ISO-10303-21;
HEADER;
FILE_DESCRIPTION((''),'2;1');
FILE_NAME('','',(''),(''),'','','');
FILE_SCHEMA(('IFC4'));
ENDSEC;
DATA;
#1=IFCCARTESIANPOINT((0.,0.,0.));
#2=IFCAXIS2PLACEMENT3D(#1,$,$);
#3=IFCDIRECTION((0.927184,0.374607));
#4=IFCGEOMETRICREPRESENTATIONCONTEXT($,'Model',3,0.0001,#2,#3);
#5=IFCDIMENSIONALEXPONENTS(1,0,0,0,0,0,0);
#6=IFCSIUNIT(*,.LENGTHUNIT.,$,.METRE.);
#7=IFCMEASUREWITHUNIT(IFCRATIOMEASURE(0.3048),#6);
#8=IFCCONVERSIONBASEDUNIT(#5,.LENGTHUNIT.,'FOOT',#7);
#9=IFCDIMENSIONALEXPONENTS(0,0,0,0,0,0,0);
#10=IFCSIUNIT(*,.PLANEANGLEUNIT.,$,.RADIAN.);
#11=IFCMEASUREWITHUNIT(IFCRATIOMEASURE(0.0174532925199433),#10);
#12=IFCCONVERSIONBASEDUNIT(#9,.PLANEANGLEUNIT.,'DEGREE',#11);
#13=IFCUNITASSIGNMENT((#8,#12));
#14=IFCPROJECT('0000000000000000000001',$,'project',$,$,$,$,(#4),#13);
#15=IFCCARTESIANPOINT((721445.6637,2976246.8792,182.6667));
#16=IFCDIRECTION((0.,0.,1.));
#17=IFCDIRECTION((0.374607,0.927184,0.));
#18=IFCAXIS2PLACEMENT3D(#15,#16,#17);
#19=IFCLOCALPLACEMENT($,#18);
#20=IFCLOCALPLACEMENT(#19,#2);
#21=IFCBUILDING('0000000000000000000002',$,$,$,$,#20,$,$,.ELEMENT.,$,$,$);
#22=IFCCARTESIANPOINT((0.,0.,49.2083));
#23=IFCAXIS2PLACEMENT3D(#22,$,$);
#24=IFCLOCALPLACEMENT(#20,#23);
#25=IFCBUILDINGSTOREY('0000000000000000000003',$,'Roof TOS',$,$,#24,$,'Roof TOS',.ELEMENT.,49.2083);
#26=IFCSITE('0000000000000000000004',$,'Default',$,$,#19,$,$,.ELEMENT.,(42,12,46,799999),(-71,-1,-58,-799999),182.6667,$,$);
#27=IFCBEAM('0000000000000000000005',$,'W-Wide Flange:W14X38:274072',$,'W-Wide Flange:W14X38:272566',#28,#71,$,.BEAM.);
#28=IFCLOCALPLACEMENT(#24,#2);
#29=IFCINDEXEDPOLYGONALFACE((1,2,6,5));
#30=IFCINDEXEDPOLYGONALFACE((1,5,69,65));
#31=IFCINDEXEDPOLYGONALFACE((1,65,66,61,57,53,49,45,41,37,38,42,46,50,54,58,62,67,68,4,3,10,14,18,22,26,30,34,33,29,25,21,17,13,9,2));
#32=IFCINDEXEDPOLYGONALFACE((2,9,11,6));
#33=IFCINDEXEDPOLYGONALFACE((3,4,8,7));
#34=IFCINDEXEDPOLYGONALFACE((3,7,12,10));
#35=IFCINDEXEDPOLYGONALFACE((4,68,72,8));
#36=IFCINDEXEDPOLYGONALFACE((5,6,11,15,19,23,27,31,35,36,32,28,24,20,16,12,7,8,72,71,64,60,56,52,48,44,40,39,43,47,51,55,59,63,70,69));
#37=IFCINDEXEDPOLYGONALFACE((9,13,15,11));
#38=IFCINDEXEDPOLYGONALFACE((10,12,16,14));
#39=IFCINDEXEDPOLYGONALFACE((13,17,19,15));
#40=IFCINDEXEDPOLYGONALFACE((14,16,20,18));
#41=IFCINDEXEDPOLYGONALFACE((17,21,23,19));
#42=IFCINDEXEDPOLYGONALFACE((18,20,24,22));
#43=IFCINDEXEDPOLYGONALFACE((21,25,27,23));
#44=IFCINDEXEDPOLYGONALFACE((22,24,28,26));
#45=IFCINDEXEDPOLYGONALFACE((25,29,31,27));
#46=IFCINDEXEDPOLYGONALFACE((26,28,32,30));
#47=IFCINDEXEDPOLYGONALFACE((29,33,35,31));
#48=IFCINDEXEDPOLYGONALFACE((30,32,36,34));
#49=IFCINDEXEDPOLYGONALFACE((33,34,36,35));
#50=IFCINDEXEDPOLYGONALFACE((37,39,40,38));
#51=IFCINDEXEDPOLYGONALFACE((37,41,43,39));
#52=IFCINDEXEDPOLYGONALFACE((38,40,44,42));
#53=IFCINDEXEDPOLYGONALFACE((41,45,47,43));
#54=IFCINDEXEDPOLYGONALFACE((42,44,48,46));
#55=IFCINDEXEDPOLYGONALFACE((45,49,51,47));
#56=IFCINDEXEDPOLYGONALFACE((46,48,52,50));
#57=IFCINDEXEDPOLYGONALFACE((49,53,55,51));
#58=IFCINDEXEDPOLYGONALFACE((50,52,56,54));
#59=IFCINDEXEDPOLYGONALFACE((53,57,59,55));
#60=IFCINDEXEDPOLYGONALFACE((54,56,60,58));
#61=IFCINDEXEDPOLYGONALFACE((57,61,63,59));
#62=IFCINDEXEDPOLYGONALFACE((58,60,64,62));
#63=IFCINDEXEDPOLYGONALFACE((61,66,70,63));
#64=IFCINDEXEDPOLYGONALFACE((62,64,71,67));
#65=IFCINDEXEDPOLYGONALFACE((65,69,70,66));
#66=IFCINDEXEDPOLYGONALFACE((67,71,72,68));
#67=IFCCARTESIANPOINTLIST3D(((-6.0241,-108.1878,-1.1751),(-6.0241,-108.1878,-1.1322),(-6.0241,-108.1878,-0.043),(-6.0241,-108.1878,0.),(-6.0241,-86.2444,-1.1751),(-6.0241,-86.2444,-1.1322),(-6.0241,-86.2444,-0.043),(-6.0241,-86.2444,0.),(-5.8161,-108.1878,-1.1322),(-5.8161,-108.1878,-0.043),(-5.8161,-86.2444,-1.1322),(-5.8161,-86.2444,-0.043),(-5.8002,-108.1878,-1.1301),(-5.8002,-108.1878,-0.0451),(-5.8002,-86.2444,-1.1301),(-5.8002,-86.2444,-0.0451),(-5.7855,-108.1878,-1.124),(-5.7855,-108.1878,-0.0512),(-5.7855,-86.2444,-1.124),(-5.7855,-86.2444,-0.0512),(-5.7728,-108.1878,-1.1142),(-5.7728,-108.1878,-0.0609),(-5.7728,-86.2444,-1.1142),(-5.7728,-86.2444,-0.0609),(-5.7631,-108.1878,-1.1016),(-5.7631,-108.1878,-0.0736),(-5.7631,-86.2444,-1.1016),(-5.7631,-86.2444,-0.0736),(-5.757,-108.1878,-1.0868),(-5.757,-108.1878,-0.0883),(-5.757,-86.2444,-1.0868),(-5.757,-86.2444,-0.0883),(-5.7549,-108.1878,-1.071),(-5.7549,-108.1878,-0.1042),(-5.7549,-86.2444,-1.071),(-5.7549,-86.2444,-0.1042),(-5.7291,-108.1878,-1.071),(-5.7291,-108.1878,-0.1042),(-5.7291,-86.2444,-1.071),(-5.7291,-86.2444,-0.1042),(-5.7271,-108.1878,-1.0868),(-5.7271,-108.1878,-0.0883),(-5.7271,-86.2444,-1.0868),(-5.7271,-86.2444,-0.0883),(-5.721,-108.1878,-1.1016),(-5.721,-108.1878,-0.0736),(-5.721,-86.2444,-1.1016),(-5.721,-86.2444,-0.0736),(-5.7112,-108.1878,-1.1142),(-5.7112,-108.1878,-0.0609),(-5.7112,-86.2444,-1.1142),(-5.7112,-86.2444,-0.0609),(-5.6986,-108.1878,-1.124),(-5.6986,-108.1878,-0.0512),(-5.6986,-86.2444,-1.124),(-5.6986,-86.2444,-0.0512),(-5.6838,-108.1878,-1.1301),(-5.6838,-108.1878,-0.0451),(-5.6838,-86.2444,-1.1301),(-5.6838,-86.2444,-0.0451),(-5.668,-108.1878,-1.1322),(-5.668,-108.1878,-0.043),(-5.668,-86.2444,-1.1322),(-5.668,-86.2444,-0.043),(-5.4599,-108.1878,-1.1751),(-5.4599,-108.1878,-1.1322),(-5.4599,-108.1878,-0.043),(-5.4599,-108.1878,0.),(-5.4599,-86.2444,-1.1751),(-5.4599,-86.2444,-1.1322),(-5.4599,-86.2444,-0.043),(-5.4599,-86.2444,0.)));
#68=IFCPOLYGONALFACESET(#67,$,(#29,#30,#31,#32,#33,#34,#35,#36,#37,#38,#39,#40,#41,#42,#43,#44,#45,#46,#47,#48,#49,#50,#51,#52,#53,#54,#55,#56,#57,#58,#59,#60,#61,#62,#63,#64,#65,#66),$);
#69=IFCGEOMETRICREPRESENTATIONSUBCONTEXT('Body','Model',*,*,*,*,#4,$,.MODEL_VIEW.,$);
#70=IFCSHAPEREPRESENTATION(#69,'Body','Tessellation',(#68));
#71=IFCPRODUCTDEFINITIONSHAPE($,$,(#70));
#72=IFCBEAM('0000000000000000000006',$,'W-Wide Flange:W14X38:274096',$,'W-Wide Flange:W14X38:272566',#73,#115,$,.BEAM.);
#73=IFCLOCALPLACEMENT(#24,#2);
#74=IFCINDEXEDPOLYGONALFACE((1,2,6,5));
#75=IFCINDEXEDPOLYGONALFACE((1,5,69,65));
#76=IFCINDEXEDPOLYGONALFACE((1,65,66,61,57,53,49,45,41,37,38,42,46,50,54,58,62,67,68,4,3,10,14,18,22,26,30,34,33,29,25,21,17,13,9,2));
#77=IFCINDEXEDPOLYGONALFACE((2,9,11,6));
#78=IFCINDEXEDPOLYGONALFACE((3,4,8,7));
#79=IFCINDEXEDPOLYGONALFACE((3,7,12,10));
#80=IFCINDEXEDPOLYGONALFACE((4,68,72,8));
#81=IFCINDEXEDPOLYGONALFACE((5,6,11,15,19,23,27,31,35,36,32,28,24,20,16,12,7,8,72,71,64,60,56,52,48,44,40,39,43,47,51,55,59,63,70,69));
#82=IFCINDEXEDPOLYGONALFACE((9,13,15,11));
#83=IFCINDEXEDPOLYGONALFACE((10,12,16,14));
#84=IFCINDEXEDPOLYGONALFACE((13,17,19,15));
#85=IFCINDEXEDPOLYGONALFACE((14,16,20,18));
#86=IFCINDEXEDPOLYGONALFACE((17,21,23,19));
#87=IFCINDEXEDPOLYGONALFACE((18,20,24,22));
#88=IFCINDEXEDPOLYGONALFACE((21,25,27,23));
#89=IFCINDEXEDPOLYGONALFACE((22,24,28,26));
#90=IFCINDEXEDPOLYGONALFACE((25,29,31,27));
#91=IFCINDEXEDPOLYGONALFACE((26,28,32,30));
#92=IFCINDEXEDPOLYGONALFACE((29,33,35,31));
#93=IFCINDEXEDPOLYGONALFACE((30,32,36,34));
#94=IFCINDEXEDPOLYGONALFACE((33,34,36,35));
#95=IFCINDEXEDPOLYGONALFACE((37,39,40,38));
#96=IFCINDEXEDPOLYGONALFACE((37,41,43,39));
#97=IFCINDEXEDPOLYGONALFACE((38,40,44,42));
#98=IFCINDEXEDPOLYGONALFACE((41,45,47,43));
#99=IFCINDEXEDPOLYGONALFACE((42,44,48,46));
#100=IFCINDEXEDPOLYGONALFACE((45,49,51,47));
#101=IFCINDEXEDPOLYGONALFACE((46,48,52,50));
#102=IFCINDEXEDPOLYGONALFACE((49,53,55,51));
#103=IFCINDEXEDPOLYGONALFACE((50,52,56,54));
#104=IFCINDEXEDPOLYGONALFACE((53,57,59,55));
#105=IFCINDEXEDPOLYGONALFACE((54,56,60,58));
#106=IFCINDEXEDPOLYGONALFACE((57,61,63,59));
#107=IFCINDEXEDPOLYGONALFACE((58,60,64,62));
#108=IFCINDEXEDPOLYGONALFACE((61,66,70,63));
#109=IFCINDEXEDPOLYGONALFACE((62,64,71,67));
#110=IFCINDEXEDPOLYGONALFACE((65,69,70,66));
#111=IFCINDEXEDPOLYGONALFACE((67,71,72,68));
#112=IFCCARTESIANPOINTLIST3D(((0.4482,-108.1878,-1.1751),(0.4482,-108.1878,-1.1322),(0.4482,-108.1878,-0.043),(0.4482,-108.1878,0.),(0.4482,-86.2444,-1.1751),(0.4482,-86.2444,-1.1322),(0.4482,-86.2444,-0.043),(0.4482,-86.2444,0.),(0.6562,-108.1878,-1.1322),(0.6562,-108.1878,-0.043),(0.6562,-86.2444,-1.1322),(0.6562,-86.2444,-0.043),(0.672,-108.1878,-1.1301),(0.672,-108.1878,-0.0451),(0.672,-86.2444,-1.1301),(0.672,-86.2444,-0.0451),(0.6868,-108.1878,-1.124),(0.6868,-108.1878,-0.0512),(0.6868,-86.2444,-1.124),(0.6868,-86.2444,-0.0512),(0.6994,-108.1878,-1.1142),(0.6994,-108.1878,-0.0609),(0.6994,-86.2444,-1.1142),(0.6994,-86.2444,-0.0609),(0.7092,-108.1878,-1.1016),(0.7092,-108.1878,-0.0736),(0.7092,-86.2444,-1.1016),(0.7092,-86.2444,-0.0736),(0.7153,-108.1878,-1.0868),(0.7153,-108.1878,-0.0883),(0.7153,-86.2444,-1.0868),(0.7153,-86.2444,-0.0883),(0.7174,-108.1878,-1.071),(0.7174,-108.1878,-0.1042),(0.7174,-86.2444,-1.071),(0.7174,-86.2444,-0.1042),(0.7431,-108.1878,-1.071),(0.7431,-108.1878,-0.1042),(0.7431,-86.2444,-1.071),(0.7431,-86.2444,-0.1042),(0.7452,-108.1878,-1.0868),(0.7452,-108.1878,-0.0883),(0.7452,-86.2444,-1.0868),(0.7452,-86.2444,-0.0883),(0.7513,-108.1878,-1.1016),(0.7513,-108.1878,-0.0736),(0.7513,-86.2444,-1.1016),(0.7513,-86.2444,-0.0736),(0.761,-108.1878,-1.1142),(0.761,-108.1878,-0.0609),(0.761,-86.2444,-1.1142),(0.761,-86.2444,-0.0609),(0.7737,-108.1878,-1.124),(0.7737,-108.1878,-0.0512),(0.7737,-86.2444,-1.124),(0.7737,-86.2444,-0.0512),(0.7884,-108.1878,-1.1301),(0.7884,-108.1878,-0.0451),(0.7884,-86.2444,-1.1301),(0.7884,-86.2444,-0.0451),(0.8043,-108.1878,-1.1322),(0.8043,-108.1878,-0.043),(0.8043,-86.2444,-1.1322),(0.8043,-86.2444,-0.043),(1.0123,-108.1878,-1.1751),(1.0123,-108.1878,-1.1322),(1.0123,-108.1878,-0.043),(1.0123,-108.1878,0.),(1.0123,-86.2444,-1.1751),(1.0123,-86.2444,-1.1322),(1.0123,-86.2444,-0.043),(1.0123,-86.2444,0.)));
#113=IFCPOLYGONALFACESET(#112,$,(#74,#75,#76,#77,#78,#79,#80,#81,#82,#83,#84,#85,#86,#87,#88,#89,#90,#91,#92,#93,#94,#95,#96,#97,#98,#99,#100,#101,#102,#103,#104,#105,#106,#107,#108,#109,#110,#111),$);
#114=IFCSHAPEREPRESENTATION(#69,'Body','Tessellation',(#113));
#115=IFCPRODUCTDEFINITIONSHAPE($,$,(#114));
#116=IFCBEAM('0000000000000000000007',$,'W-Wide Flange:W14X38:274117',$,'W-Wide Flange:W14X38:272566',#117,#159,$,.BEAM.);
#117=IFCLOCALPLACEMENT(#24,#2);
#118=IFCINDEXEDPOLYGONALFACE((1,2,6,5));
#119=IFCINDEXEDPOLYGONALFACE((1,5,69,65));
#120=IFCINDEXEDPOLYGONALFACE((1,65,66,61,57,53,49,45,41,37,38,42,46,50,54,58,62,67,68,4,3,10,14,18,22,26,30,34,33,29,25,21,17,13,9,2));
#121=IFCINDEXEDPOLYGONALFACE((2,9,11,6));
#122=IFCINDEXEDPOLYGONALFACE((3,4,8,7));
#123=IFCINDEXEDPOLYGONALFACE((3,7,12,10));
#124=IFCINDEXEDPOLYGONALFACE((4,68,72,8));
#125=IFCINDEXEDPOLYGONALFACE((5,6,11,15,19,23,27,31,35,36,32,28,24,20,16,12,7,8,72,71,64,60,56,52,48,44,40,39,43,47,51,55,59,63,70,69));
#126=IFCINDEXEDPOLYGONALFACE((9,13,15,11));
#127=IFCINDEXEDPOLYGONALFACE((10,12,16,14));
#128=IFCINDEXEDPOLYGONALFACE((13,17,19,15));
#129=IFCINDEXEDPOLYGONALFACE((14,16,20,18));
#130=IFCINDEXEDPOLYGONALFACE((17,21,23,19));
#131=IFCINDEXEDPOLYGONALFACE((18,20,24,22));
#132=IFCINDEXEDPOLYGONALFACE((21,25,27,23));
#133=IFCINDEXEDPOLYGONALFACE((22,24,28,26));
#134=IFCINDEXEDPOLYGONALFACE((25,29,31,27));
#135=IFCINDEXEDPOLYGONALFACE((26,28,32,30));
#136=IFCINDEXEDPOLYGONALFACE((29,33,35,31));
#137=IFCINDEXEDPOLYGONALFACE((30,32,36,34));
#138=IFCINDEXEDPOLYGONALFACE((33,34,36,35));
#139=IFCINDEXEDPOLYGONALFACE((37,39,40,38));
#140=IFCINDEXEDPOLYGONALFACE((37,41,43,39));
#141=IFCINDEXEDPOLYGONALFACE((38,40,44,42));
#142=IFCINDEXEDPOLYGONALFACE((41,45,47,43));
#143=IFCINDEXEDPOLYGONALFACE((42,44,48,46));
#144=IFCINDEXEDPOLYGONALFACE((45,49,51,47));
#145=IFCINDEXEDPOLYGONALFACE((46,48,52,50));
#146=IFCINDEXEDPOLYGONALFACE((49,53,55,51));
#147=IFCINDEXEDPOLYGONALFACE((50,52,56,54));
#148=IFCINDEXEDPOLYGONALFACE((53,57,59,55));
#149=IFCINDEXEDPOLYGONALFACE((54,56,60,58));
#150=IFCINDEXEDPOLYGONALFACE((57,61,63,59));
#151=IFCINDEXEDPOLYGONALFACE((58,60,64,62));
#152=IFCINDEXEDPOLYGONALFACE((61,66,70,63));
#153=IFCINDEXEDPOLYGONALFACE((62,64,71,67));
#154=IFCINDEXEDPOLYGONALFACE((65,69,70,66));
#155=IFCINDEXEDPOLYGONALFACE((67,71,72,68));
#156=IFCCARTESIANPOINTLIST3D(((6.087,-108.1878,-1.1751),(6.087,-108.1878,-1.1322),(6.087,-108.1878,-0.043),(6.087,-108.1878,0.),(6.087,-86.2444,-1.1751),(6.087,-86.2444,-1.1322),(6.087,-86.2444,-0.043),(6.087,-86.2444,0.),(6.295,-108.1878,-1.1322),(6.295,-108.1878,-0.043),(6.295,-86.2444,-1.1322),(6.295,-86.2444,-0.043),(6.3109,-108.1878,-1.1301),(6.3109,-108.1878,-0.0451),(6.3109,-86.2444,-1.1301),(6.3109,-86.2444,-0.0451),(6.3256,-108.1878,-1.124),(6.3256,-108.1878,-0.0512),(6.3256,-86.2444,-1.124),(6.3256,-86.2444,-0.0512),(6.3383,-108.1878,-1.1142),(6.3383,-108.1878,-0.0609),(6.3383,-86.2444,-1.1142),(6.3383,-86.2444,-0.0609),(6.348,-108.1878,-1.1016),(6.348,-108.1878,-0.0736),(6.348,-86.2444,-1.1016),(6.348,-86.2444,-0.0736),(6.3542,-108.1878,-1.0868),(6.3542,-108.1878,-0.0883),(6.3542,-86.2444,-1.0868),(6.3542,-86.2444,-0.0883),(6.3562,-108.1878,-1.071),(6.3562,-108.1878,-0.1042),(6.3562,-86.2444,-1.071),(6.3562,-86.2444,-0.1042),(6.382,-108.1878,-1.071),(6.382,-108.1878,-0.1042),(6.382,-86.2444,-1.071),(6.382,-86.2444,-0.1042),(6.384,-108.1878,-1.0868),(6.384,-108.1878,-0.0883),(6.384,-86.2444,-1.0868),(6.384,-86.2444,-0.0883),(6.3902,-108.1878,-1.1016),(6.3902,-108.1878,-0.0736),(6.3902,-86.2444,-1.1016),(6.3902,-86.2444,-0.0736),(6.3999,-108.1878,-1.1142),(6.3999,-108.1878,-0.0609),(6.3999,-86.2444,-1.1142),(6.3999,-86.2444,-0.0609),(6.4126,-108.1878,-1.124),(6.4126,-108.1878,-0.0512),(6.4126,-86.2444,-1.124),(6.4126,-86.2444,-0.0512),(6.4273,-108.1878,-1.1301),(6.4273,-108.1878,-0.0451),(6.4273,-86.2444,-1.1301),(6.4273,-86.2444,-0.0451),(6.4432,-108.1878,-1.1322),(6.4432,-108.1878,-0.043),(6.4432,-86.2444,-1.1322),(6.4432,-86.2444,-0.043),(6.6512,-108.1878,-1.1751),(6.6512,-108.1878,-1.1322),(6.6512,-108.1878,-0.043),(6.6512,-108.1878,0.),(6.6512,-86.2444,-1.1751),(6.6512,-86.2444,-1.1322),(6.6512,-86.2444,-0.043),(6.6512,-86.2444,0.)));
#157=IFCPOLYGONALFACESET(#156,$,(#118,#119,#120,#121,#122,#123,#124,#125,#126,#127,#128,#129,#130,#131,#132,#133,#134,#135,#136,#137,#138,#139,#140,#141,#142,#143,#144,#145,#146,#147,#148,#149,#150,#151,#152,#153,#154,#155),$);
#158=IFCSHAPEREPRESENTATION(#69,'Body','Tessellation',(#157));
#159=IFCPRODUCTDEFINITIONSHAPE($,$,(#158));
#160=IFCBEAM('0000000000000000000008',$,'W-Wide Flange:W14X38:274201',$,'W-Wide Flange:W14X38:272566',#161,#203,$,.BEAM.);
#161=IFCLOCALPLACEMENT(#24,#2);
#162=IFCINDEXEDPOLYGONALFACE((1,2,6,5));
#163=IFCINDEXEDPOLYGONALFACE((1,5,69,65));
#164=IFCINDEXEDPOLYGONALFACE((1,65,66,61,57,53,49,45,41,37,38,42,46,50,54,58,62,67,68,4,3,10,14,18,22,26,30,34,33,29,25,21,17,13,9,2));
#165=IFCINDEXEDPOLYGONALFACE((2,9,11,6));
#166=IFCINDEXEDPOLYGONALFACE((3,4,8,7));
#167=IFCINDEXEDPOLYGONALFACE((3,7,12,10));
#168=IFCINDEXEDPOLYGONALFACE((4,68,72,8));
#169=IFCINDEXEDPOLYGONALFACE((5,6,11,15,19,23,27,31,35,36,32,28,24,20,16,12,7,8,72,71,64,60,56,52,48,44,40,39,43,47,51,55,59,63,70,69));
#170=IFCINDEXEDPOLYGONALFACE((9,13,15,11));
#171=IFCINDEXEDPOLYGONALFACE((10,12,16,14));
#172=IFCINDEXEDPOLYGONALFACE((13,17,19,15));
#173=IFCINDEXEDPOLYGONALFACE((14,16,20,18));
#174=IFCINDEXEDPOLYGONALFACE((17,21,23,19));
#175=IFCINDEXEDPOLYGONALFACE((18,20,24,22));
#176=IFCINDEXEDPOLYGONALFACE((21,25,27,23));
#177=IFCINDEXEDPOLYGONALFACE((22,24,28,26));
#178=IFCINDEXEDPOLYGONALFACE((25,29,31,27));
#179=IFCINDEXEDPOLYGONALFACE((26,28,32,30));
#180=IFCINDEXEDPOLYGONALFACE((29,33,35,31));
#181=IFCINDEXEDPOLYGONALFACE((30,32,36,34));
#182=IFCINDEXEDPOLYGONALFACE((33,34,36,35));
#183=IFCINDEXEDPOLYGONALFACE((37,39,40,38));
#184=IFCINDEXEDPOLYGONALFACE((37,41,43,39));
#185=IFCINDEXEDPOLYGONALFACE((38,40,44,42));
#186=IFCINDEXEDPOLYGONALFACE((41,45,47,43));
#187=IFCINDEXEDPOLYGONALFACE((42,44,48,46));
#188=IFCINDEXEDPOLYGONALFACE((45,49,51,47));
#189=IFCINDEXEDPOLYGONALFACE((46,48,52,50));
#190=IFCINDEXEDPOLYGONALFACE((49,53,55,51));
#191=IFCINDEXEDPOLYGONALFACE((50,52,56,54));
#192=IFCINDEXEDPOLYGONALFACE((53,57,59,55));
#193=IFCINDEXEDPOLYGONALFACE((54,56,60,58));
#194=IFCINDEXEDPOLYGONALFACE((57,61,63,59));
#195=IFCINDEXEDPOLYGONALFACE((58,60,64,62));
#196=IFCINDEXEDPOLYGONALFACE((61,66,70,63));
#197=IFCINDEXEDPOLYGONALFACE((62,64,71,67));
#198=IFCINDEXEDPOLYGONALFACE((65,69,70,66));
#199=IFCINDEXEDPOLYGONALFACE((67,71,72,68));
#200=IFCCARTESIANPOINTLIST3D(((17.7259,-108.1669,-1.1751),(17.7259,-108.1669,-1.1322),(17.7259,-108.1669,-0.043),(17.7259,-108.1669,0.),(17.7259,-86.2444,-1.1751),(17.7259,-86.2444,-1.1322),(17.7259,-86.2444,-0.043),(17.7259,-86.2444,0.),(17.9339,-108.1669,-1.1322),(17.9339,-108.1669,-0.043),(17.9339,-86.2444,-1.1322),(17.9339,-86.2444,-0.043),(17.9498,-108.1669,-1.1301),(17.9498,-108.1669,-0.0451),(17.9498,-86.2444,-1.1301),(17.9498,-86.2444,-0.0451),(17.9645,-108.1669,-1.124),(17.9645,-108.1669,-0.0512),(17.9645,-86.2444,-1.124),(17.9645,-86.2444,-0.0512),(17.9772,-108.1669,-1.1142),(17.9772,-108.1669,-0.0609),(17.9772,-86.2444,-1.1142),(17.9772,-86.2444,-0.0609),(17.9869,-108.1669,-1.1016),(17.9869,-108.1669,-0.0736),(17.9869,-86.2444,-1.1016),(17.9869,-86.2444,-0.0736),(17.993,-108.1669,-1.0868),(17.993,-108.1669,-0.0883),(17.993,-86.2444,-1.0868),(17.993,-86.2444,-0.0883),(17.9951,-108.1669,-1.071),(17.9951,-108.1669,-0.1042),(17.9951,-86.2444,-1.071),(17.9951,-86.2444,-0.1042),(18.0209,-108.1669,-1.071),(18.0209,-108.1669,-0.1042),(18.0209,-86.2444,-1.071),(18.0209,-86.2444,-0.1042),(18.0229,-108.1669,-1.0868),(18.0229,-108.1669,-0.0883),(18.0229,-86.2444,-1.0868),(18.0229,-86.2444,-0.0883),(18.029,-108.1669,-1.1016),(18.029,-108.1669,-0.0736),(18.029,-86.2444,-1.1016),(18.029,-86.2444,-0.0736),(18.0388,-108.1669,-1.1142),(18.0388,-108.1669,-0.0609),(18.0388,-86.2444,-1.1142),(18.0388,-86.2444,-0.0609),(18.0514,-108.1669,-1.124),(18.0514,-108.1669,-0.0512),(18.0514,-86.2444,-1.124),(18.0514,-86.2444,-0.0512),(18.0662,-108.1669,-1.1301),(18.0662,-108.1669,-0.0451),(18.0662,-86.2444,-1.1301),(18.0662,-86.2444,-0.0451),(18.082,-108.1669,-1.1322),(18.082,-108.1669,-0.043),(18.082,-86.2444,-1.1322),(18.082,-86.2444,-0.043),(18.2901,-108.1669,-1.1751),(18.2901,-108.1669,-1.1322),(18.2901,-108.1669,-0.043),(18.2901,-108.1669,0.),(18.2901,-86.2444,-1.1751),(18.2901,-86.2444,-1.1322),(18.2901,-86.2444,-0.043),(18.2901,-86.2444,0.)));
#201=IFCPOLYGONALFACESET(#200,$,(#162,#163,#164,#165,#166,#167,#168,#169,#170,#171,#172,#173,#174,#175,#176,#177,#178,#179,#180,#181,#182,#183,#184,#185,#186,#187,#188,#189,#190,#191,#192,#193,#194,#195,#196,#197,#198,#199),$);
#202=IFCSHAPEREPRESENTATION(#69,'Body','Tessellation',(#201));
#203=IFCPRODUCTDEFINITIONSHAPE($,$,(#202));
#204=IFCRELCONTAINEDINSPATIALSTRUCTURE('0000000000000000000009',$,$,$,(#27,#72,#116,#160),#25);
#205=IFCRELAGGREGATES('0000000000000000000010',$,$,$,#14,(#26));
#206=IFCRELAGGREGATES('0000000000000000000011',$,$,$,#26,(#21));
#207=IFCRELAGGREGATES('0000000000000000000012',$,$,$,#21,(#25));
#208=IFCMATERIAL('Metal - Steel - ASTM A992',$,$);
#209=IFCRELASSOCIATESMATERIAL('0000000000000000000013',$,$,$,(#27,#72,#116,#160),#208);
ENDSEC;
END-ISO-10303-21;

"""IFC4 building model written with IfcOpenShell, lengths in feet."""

from ifc_helpers import new_model, entity, si_unit, converted_unit, direction, frame, frame_2d, origin, place, context, subcontext, project, spatial, i_section, extrude, material, element, save


model = new_model("IFC4")

# Units and contexts
model_context = context("Model", 3, precision=0.0001, world=origin(), true_north=direction((0.927184, 0.374607)))
body_context = subcontext(model_context, "Body", "Model", "MODEL_VIEW")
ifc_project = project(units=[converted_unit("LENGTHUNIT", "FOOT", entity("IfcRatioMeasure", 0.3048), si_unit("LENGTHUNIT", "METRE"), dimensions=[1, 0, 0, 0, 0, 0, 0]), converted_unit("PLANEANGLEUNIT", "DEGREE", entity("IfcRatioMeasure", 0.0174532925199433), si_unit("PLANEANGLEUNIT", "RADIAN"), dimensions=[0, 0, 0, 0, 0, 0, 0])], contexts=[model_context])

# Site, building, storey
site_placement = place(None, frame((721445.6637, 2976246.8792, 182.6667), z_axis=(0.0, 0.0, 1.0), x_axis=(0.374607, 0.927184, 0.0)))
site = spatial("IfcSite", under=ifc_project, at=site_placement, Name="Default", CompositionType="ELEMENT", RefLatitude=(42, 12, 46, 799999), RefLongitude=(-71, -1, -58, -799999), RefElevation=182.6667)
building_placement = place(site_placement, origin())
building = spatial("IfcBuilding", under=site, at=building_placement, CompositionType="ELEMENT")
storey_placement = place(building_placement, frame((0.0, 0.0, 49.2083)))
storey = spatial("IfcBuildingStorey", under=building, at=storey_placement, Name="Roof TOS", LongName="Roof TOS", CompositionType="ELEMENT", Elevation=49.2083)

# Beams
ifc_material = material(Name="Metal - Steel - ASTM A992")
beam_1_placement = place(storey_placement, frame((-5.742, -85.8544, 0.0), z_axis=(0.0, 0.0, 1.0), x_axis=(0.0, -1.0, 0.0)))
element("IfcBeam", 1, at=beam_1_placement, inside=storey, material=ifc_material, Name="W-Wide Flange:W14X38:274072", ObjectType="W-Wide Flange:W14X38:272566", PredefinedType="BEAM", context=body_context, shape_type="SweptSolid", body=[
    extrude(i_section(OverallWidth=0.5641, OverallDepth=1.1751, WebThickness=0.0257, FlangeThickness=0.043, FilletRadius=0.0612, at=frame_2d((0.0, 0.0), x_axis=(0.0, 1.0))), frame((0.39, 0.0, -0.5876), z_axis=(1.0, 0.0, 0.0), x_axis=(0.0, 0.0, -1.0)), (0.0, 0.0, 1.0), 21.9434),
])
beam_2_placement = place(storey_placement, frame((0.7302, -85.8544, 0.0), z_axis=(0.0, 0.0, 1.0), x_axis=(0.0, -1.0, 0.0)))
element("IfcBeam", 2, at=beam_2_placement, inside=storey, material=ifc_material, Name="W-Wide Flange:W14X38:274096", ObjectType="W-Wide Flange:W14X38:272566", PredefinedType="BEAM", context=body_context, shape_type="SweptSolid", body=[
    extrude(i_section(OverallWidth=0.5641, OverallDepth=1.1751, WebThickness=0.0257, FlangeThickness=0.043, FilletRadius=0.0612, at=frame_2d((0.0, 0.0), x_axis=(0.0, 1.0))), frame((0.39, 0.0, -0.5876), z_axis=(1.0, 0.0, 0.0), x_axis=(0.0, 0.0, -1.0)), (0.0, 0.0, 1.0), 21.9434),
])
beam_3_placement = place(storey_placement, frame((6.3691, -85.8544, 0.0), z_axis=(0.0, 0.0, 1.0), x_axis=(0.0, -1.0, 0.0)))
element("IfcBeam", 3, at=beam_3_placement, inside=storey, material=ifc_material, Name="W-Wide Flange:W14X38:274117", ObjectType="W-Wide Flange:W14X38:272566", PredefinedType="BEAM", context=body_context, shape_type="SweptSolid", body=[
    extrude(i_section(OverallWidth=0.5641, OverallDepth=1.1751, WebThickness=0.0257, FlangeThickness=0.043, FilletRadius=0.0612, at=frame_2d((0.0, 0.0), x_axis=(0.0, 1.0))), frame((0.39, 0.0, -0.5876), z_axis=(1.0, 0.0, 0.0), x_axis=(0.0, 0.0, -1.0)), (0.0, 0.0, 1.0), 21.9434),
])
for number, where, z_axis, x_axis, name in (
    (4, (18.008, -85.8544, 0.0), (0.0, 0.0, 1.0), (0.0, -1.0, 0.0), "W-Wide Flange:W14X38:274201"),
):
    element("IfcBeam", number, at=place(storey_placement, frame(where, z_axis=z_axis, x_axis=x_axis)), inside=storey, material=ifc_material, Name=name, ObjectType="W-Wide Flange:W14X38:272566", PredefinedType="BEAM", context=body_context, shape_type="SweptSolid", body=[
        extrude(i_section(OverallWidth=0.5641, OverallDepth=1.1751, WebThickness=0.0257, FlangeThickness=0.043, FilletRadius=0.0612, at=frame_2d((0.0, 0.0), x_axis=(0.0, 1.0))), frame((0.39, 0.0, -0.5876), z_axis=(1.0, 0.0, 0.0), x_axis=(0.0, 0.0, -1.0)), (0.0, 0.0, 1.0), 21.9225),
    ])

save(model, "model.ifc")
